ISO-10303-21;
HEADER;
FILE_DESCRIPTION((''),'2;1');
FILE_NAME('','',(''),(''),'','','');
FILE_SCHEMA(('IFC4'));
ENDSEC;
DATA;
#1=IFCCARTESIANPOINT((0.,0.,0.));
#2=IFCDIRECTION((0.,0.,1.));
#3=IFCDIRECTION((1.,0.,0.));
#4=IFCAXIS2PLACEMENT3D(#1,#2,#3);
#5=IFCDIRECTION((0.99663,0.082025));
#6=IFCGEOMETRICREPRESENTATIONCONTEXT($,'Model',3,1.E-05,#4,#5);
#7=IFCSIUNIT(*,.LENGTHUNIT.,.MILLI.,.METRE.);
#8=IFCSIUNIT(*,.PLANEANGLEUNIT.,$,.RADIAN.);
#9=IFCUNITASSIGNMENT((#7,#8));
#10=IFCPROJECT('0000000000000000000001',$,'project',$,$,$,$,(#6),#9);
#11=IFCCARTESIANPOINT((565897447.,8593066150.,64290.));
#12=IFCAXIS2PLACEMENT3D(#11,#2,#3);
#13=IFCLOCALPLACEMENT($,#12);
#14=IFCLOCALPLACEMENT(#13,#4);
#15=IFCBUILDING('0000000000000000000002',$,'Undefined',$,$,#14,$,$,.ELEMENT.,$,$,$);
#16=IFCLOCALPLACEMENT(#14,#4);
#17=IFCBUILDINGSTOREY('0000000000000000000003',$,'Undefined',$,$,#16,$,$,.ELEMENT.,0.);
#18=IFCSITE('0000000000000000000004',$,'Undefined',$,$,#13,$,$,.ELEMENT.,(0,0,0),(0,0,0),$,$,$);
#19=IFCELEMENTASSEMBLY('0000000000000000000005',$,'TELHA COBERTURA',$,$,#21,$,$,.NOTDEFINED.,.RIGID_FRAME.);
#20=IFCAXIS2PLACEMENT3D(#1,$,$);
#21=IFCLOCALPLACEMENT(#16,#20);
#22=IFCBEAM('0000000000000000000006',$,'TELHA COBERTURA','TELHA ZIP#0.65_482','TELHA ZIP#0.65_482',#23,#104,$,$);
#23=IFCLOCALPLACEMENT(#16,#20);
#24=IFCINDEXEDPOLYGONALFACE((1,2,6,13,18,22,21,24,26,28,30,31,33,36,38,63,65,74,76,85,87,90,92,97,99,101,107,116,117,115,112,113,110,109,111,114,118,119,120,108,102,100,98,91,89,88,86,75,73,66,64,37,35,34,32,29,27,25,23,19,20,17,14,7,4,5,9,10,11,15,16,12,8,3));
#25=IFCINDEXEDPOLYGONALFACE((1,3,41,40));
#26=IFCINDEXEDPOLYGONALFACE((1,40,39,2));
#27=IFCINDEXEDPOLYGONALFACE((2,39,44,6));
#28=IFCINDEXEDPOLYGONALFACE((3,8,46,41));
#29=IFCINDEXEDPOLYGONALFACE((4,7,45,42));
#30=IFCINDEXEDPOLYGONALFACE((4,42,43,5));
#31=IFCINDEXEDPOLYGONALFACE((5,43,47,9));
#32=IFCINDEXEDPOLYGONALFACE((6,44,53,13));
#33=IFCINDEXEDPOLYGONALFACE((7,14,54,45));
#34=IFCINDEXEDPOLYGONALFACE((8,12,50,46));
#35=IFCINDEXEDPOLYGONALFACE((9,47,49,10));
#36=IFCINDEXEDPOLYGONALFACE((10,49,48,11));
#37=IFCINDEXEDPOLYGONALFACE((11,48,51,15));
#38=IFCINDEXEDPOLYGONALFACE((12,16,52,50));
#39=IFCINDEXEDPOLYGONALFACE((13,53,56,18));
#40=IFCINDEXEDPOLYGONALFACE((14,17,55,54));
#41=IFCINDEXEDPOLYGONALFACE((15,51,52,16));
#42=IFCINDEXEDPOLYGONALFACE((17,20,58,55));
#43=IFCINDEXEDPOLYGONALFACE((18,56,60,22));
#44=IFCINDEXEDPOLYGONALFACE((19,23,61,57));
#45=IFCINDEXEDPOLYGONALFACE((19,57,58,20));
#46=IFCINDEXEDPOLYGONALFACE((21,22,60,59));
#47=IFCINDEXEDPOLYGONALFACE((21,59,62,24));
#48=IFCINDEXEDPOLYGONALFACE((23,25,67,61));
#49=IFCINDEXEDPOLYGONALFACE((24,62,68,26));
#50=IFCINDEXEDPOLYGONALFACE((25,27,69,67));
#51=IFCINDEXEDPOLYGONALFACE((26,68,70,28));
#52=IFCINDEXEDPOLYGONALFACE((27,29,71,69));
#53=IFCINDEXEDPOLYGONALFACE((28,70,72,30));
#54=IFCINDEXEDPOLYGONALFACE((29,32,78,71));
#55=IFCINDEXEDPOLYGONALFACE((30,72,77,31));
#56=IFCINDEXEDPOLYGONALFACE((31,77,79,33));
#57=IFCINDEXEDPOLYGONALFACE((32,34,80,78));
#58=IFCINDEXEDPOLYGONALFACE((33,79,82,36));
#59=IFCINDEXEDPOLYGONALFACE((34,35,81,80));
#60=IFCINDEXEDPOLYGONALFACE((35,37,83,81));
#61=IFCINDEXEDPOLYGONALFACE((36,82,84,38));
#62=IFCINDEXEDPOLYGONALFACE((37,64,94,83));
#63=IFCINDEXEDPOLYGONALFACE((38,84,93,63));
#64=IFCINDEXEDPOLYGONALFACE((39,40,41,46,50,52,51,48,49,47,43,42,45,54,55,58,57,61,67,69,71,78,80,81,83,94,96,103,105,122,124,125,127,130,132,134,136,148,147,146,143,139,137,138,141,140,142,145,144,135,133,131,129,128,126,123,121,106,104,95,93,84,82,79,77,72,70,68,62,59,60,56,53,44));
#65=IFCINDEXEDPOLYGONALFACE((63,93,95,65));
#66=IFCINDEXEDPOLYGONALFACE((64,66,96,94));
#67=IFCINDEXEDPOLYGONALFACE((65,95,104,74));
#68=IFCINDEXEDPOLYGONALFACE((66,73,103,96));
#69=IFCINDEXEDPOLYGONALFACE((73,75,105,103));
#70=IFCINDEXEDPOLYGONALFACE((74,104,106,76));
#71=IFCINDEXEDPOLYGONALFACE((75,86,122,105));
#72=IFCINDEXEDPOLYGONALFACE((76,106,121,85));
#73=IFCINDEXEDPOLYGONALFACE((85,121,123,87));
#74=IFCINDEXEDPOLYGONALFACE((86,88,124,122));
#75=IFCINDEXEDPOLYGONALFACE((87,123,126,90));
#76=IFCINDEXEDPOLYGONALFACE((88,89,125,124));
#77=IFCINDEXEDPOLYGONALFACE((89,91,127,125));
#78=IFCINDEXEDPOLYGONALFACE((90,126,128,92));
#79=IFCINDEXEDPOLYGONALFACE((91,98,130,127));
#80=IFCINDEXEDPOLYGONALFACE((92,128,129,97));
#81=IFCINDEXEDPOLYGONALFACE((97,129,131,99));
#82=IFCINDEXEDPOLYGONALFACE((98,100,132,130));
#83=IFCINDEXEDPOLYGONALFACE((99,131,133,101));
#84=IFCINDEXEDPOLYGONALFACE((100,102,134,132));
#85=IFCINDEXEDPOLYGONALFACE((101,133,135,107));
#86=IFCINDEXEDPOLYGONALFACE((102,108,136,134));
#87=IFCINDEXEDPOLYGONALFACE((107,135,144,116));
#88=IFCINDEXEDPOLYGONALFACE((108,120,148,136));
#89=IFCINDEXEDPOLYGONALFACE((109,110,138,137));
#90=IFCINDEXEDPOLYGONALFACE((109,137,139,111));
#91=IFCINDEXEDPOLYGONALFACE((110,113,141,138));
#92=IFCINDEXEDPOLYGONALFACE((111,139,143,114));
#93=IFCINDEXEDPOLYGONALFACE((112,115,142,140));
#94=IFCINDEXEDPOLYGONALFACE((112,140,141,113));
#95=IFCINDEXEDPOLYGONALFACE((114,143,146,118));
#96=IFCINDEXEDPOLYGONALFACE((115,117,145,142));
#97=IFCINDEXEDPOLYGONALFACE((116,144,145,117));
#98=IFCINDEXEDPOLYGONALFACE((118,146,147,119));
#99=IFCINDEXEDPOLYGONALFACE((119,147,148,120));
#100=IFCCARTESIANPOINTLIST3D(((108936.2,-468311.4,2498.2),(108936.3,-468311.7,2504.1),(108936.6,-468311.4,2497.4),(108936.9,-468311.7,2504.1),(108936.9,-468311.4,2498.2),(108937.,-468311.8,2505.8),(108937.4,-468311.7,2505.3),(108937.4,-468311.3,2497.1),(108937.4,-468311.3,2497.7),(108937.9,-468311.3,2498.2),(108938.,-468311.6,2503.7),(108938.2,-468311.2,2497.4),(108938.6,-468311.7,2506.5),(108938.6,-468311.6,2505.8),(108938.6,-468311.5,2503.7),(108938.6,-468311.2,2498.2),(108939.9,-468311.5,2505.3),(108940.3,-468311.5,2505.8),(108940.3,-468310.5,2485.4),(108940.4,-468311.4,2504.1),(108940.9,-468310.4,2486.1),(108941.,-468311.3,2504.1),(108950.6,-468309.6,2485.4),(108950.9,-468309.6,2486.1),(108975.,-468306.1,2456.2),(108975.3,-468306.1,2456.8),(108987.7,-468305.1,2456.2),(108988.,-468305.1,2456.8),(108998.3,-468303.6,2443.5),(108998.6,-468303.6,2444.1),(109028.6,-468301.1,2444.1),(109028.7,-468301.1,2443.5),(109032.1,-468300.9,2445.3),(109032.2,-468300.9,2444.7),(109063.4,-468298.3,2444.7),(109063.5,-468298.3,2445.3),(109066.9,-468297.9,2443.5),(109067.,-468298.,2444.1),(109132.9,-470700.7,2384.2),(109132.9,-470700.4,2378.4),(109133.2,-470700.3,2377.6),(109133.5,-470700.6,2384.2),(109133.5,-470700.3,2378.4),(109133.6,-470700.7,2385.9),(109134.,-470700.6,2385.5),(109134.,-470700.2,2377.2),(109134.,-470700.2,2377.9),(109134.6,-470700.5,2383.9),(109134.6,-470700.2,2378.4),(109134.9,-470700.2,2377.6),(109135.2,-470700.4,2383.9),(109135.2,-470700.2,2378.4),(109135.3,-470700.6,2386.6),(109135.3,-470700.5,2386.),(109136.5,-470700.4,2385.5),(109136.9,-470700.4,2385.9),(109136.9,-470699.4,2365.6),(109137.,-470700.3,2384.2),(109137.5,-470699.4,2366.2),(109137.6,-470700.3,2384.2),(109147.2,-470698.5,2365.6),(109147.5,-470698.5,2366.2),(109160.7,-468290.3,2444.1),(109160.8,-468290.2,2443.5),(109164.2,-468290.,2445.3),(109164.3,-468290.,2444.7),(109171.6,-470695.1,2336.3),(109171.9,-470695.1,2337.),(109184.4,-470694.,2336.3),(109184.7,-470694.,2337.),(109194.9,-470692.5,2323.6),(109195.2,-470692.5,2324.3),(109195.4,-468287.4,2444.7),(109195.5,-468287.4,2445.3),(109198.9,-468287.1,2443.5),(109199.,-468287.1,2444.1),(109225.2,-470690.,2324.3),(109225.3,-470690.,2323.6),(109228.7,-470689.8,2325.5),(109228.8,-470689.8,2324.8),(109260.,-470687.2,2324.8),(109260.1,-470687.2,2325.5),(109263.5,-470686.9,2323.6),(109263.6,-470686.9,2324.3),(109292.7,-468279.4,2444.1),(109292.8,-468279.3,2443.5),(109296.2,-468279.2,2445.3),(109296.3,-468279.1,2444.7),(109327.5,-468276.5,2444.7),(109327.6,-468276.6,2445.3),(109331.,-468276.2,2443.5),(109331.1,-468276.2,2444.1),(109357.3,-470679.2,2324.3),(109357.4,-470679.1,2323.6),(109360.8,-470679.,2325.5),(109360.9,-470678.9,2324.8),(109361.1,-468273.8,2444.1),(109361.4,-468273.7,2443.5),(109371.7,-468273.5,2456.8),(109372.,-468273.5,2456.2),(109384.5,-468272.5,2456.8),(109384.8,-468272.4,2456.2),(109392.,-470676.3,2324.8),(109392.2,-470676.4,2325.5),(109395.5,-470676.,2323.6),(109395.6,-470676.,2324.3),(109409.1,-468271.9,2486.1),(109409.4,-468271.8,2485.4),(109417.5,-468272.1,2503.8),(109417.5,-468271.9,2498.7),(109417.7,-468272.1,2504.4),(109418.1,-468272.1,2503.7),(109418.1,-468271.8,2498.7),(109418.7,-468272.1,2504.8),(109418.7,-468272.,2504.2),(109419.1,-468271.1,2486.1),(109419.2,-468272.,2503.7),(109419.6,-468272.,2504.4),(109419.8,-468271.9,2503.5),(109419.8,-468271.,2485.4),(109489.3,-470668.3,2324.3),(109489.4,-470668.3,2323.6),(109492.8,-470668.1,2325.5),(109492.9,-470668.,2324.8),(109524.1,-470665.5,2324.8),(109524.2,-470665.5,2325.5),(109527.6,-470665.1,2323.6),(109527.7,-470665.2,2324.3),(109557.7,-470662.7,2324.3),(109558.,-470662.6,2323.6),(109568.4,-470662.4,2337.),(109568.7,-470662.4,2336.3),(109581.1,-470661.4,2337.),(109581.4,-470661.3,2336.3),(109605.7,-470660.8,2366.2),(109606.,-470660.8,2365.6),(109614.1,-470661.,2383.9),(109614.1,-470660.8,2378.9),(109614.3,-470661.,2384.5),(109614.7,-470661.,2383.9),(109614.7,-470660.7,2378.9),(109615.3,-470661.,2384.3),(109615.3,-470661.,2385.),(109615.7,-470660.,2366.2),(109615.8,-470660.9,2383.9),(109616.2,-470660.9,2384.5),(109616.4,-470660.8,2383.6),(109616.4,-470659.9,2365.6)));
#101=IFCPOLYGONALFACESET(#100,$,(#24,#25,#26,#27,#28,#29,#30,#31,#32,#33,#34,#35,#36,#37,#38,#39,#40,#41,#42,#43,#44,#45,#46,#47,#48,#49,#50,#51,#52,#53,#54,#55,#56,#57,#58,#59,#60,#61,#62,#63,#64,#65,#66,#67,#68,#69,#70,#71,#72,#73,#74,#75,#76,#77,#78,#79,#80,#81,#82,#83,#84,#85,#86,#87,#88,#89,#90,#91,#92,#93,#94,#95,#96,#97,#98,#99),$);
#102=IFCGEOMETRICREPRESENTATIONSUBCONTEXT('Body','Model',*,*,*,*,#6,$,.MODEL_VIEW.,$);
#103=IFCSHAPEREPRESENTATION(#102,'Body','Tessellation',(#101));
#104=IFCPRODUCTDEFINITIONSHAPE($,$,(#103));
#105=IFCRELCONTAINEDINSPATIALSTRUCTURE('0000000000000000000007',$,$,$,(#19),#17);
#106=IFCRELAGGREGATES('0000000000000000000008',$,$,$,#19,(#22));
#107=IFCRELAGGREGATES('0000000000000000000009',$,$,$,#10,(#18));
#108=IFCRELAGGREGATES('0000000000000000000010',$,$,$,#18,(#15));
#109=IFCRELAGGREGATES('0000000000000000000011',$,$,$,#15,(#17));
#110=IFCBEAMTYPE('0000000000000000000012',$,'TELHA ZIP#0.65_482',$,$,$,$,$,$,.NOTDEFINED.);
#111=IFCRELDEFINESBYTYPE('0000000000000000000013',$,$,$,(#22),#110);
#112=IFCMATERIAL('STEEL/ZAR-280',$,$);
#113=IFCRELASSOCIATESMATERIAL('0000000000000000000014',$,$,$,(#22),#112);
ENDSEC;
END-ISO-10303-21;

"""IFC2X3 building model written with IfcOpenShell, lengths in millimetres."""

from ifc_helpers import new_model, si_unit, direction, frame, origin_with_axes, place, context, subcontext, project, spatial, polyline, outline, extrude, material, type_object, element, aggregate, save


model = new_model("IFC2X3")

# Units and contexts
model_context = context("Model", 3, precision=1e-05, world=origin_with_axes(), true_north=direction((0.99663, 0.082025)))
body_context = subcontext(model_context, "Body", "Model", "MODEL_VIEW")
ifc_project = project(units=[si_unit("LENGTHUNIT", "METRE", prefix="MILLI"), si_unit("PLANEANGLEUNIT", "RADIAN")], contexts=[model_context])

# Site, building, storey
site_placement = place(None, frame((565897447.0, 8593066150.0, 64290.0), z_axis=(0.0, 0.0, 1.0), x_axis=(1.0, 0.0, 0.0)))
site = spatial("IfcSite", under=ifc_project, at=site_placement, Name="Undefined", CompositionType="ELEMENT", RefLatitude=(0, 0, 0), RefLongitude=(0, 0, 0))
building_placement = place(site_placement, origin_with_axes())
building = spatial("IfcBuilding", under=site, at=building_placement, Name="Undefined", CompositionType="ELEMENT")
storey_placement = place(building_placement, origin_with_axes())
storey = spatial("IfcBuildingStorey", under=building, at=storey_placement, Name="Undefined", CompositionType="ELEMENT", Elevation=0.0)

# Element assembly, beam
ifc_material_1 = material(Name="STEEL/ZAR-280")
beam_type_1 = type_object("IfcBeamType", Name="TELHA ZIP#0.65_482", PredefinedType="NOTDEFINED")
assembly_1_placement = place(storey_placement, origin_with_axes())
assembly_1 = element("IfcElementAssembly", 1, at=assembly_1_placement, inside=storey, Name="TELHA COBERTURA", AssemblyPlace="NOTDEFINED", PredefinedType="RIGID_FRAME")
beam_1_placement = place(assembly_1_placement, frame((109374.5, -470679.3, 2354.8), z_axis=(0.004096, -0.049769, 0.998752), x_axis=(-0.081923, 0.995387, 0.049938)))
beam_1 = element("IfcBeam", 2, at=beam_1_placement, type_object=beam_type_1, material=ifc_material_1, Name="TELHA COBERTURA", Description="TELHA ZIP#0.65_482", ObjectType="TELHA ZIP#0.65_482", context=body_context, shape_type="SweptSolid", body=[
    extrude(outline(polyline([(240.5, 29.7), (241.4, 30.2), (242.4, 29.7), (242.6, 28.9), (242.6, 10.8), (232.2, 10.8), (207.6, -18.5), (194.9, -18.5), (184.2, -31.2), (153.7, -31.2), (150.2, -30.0), (118.9, -30.0), (115.4, -31.2), (21.2, -31.2), (17.7, -30.0), (-13.6, -30.0), (-17.1, -31.2), (-111.3, -31.2), (-114.8, -30.0), (-146.1, -30.0), (-149.6, -31.2), (-180.1, -31.2), (-190.8, -18.5), (-203.6, -18.5), (-228.1, 10.8), (-238.5, 10.8), (-238.5, 29.5), (-239.0, 30.7), (-240.2, 31.2), (-241.4, 30.7), (-241.9, 29.5), (-241.9, 23.6), (-241.4, 23.1), (-240.9, 23.6), (-240.9, 29.1), (-240.2, 29.1), (-240.2, 23.6), (-240.6, 22.8), (-241.4, 22.4), (-242.3, 22.8), (-242.6, 23.6), (-242.6, 29.5), (-241.9, 31.2), (-240.2, 31.9), (-238.5, 31.2), (-237.9, 29.5), (-237.9, 11.4), (-227.8, 11.4), (-203.2, -17.9), (-190.4, -17.9), (-179.8, -30.5), (-149.7, -30.5), (-146.2, -29.4), (-114.7, -29.4), (-111.2, -30.5), (-17.2, -30.5), (-13.7, -29.4), (17.8, -29.4), (21.3, -30.5), (115.3, -30.5), (118.8, -29.4), (150.3, -29.4), (153.8, -30.5), (183.9, -30.5), (194.6, -17.9), (207.4, -17.9), (231.9, 11.4), (241.9, 11.4), (241.9, 29.1), (241.4, 29.5), (240.9, 29.1), (240.9, 24.1), (240.2, 24.1), (240.2, 29.2), (240.5, 29.7)])), frame((2400.0, 0.0, 0.0), z_axis=(-1.0, 0.0, 0.0), x_axis=(0.0, -1.0, 0.0)), (0.0, 0.0, 1.0), 2400.0),
])
aggregate(assembly_1, [beam_1])

save(model, "model.ifc")
